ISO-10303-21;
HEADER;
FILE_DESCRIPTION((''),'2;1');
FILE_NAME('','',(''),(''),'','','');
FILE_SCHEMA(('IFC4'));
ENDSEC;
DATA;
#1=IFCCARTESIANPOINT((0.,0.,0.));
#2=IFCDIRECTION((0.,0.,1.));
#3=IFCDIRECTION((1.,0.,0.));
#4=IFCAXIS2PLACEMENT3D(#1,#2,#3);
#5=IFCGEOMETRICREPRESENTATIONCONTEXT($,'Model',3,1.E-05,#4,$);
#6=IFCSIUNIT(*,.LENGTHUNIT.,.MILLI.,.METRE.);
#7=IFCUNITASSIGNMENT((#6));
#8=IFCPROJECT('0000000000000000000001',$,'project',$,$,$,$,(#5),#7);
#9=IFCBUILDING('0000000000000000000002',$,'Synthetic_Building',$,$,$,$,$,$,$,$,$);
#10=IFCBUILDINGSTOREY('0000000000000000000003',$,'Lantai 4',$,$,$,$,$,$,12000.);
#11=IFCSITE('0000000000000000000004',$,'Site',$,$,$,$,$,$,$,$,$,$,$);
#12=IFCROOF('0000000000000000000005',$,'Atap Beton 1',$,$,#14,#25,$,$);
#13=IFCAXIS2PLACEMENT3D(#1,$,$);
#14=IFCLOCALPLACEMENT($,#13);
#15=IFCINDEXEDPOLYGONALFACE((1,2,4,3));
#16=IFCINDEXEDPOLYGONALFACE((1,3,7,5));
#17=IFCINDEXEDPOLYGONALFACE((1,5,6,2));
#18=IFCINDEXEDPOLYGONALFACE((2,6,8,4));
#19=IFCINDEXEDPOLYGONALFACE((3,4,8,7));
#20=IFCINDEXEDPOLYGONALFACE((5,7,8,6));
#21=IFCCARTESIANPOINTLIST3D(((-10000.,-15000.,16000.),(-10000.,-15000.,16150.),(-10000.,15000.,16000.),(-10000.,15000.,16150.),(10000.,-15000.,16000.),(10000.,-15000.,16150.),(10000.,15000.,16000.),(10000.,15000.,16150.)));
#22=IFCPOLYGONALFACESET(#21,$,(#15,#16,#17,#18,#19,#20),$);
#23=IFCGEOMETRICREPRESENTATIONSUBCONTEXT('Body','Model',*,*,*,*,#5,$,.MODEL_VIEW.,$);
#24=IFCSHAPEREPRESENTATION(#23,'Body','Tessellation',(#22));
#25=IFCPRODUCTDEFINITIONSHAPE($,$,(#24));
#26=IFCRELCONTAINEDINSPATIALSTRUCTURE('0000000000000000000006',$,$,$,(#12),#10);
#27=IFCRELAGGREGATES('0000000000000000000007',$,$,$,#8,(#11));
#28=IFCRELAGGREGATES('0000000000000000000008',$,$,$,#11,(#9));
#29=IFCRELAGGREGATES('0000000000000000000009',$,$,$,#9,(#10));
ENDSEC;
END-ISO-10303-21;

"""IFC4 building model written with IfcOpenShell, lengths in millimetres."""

from ifc_helpers import new_model, si_unit, frame, origin_with_axes, place, context, subcontext, project, spatial, polyline, outline, extrude, element, save


model = new_model("IFC4")

# Units and contexts
model_context = context("Model", 3, precision=1e-05, world=origin_with_axes())
body_context = subcontext(model_context, "Body", "Model", "MODEL_VIEW")
ifc_project = project(units=[si_unit("LENGTHUNIT", "METRE", prefix="MILLI")], contexts=[model_context])

# Site, building, storey
site = spatial("IfcSite", under=ifc_project, Name="Site")
building = spatial("IfcBuilding", under=site, Name="Synthetic_Building")
storey = spatial("IfcBuildingStorey", under=building, Name="Lantai 4", Elevation=12000.0)

# Roof
roof_placement = place(None, origin_with_axes())
element("IfcRoof", 1, at=roof_placement, inside=storey, Name="Atap Beton 1", context=body_context, shape_type="SweptSolid", body=[
    extrude(outline(polyline([(-10000.0, -15000.0), (10000.0, -15000.0), (10000.0, 15000.0), (-10000.0, 15000.0), (-10000.0, -15000.0)])), frame((0.0, 0.0, 16000.0), z_axis=(0.0, 0.0, 1.0), x_axis=(1.0, 0.0, 0.0)), (0.0, 0.0, 1.0), 150.0),
])

save(model, "model.ifc")
